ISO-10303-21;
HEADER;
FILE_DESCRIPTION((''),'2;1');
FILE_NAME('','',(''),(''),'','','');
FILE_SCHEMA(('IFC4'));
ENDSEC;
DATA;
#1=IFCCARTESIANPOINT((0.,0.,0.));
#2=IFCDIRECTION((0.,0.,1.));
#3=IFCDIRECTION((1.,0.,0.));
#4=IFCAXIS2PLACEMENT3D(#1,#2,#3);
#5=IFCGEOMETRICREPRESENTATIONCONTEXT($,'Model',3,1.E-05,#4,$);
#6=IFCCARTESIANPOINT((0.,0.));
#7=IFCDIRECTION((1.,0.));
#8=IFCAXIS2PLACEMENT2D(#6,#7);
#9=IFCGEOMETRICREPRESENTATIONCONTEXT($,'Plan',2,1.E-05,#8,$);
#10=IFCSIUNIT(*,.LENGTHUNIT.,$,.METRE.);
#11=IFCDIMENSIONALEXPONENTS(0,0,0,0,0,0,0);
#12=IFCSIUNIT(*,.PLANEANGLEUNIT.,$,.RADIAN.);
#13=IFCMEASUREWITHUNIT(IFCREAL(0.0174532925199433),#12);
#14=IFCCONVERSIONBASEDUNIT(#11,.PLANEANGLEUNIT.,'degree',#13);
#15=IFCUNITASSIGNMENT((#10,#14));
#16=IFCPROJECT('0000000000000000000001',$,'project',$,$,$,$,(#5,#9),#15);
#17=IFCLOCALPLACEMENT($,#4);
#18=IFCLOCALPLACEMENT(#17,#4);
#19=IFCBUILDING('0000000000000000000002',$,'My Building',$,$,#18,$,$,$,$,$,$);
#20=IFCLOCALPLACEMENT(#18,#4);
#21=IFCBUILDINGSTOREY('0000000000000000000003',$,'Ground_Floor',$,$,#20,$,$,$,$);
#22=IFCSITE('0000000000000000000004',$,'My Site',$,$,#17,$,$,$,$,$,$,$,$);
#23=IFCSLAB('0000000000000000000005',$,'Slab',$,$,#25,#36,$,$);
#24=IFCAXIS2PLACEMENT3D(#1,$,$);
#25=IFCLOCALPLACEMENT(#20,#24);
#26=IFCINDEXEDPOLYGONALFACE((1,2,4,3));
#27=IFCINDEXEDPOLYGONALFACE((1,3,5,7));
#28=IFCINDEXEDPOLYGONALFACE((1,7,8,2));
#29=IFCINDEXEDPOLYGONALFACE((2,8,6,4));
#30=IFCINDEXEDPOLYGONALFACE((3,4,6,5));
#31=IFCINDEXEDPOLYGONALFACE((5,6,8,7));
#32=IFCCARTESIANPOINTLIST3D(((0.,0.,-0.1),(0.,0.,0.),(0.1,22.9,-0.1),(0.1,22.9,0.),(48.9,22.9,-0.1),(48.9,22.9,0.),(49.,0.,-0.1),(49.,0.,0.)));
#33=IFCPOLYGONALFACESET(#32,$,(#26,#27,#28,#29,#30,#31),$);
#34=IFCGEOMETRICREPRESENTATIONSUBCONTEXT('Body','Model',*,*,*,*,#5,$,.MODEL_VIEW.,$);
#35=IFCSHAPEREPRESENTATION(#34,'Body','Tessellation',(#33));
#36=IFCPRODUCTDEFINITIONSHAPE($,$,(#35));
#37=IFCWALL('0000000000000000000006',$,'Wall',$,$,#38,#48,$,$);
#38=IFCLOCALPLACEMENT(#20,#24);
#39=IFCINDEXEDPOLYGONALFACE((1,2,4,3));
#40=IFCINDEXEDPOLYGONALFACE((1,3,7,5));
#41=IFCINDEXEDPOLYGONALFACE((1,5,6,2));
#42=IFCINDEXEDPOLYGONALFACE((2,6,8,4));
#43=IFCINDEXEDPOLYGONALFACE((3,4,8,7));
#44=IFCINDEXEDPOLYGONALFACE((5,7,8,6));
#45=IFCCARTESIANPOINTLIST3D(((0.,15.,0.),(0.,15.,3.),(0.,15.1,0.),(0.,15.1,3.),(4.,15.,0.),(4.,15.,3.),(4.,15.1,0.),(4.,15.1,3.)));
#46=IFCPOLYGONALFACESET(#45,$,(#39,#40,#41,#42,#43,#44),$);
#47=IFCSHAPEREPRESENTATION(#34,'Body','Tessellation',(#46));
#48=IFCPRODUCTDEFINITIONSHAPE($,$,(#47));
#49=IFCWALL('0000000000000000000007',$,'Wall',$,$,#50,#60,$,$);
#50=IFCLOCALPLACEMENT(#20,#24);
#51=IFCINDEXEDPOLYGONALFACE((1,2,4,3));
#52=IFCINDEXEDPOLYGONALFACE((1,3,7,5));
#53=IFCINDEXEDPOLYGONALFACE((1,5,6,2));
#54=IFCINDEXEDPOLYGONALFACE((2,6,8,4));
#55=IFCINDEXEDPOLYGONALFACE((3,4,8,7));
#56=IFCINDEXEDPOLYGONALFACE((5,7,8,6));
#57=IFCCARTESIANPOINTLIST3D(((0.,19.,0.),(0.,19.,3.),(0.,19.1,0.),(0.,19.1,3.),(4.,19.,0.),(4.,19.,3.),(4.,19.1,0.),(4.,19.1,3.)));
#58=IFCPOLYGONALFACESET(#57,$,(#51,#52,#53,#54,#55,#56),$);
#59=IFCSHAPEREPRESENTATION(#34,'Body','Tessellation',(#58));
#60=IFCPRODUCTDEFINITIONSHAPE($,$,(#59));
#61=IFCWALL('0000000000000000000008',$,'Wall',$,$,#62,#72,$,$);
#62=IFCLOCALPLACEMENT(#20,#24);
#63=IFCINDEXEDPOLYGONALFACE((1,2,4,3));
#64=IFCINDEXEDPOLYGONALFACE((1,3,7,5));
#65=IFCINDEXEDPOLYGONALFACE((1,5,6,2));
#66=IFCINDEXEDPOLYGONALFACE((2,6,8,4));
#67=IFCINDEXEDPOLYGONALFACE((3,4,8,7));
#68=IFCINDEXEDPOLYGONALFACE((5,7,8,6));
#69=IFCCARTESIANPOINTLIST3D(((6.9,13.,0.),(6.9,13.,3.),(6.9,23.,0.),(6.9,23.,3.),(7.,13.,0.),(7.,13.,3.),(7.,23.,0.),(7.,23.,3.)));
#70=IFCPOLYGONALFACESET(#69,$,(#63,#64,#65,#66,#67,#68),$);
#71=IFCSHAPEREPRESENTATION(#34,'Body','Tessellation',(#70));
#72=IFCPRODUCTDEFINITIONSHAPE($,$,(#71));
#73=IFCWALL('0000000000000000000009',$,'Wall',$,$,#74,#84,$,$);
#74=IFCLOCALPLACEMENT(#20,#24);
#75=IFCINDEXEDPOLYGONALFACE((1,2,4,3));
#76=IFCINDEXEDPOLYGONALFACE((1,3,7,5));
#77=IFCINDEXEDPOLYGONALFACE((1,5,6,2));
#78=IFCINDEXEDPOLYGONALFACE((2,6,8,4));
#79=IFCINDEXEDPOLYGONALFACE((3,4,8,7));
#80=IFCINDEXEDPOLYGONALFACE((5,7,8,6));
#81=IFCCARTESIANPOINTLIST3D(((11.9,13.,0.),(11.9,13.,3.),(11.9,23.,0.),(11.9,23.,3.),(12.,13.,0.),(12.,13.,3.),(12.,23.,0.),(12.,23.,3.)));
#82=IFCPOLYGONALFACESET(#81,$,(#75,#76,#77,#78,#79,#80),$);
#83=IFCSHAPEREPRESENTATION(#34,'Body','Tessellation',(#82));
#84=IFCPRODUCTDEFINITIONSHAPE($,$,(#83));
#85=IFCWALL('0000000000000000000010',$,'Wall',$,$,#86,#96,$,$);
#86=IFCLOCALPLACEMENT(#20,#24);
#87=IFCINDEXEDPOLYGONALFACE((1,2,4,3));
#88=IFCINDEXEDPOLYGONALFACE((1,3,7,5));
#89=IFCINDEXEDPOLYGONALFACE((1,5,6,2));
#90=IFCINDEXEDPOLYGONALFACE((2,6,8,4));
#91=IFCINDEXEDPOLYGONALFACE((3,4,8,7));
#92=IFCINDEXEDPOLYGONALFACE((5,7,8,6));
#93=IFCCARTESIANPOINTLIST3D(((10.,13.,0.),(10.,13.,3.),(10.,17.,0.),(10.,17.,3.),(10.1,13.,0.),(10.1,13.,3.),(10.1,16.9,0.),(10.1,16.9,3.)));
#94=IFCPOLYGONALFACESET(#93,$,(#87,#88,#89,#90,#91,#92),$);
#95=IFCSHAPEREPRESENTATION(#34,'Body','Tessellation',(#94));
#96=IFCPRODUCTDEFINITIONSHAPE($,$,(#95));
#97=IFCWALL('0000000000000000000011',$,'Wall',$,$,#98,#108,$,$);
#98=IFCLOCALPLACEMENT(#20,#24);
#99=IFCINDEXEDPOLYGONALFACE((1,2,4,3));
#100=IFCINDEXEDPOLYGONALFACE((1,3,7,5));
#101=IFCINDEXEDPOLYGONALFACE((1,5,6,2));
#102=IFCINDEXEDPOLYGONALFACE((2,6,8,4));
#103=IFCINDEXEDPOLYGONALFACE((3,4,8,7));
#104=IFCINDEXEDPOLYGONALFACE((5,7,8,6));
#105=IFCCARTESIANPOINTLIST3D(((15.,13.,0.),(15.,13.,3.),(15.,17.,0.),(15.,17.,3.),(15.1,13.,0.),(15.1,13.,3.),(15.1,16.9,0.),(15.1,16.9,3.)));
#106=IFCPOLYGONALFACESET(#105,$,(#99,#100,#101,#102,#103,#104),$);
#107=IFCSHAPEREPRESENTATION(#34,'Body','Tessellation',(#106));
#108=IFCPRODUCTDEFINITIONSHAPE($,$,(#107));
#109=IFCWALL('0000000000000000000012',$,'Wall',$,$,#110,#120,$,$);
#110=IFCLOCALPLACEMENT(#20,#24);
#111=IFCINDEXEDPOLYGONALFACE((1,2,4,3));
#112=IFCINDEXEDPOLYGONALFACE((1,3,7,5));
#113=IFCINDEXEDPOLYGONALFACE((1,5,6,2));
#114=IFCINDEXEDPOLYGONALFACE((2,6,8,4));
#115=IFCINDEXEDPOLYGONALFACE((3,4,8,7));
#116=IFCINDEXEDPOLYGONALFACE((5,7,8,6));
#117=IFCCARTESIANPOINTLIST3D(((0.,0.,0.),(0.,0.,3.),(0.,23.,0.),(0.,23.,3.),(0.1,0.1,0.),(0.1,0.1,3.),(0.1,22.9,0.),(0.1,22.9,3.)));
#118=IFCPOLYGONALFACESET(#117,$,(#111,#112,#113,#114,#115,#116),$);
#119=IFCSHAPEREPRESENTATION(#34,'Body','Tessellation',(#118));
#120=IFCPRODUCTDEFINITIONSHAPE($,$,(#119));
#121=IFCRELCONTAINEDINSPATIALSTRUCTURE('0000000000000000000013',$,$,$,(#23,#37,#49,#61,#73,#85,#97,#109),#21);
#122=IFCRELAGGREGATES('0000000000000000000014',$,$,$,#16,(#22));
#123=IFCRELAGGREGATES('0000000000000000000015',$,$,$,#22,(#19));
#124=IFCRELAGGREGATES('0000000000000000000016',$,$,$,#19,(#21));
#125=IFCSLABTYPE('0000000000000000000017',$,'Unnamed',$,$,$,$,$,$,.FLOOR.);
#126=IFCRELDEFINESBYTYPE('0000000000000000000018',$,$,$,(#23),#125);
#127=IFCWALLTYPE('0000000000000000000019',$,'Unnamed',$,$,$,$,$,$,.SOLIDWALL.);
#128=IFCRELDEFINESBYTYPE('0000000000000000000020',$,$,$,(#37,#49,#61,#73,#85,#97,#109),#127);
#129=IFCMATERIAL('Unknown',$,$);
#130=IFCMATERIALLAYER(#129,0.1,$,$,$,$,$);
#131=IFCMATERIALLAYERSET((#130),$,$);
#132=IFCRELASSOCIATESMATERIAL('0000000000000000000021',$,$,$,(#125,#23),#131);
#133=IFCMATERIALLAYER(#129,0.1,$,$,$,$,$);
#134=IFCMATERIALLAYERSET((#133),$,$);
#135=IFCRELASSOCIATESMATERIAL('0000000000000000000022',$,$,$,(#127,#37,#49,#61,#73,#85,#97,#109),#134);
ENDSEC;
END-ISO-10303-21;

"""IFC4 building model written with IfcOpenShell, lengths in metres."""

from ifc_helpers import new_model, entity, si_unit, converted_unit, frame, origin_with_axes, origin_2d_with_axis, place, context, subcontext, project, spatial, line, indexed_curve, outline, extrude, material, layer, layer_set, layer_usage, type_object, element, save


model = new_model("IFC4")

# Units and contexts
model_context = context("Model", 3, precision=1e-05, world=origin_with_axes())
plan_context = context("Plan", 2, precision=1e-05, world=origin_2d_with_axis())
body_context_1 = subcontext(model_context, "Body", "Model", "MODEL_VIEW")
ifc_project = project(units=[si_unit("LENGTHUNIT", "METRE"), converted_unit("PLANEANGLEUNIT", "degree", entity("IfcReal", 0.0174532925199433), si_unit("PLANEANGLEUNIT", "RADIAN"), dimensions=[0, 0, 0, 0, 0, 0, 0])], contexts=[model_context, plan_context])

# Site, building, storey
site_placement = place(None, origin_with_axes())
site = spatial("IfcSite", under=ifc_project, at=site_placement, Name="My Site")
building_placement = place(site_placement, origin_with_axes())
building = spatial("IfcBuilding", under=site, at=building_placement, Name="My Building")
storey_placement = place(building_placement, origin_with_axes())
storey = spatial("IfcBuildingStorey", under=building, at=storey_placement, Name="Ground_Floor")

# Slab
ifc_material = material(Name="Unknown")
ifc_layer_1 = layer(ifc_material, 0.1)
ifc_layer_set_1 = layer_set([ifc_layer_1])
ifc_layer_usage_1 = layer_usage(ifc_layer_set_1, "AXIS3", "POSITIVE", -0.1)
slab_type = type_object("IfcSlabType", Name="Unnamed", PredefinedType="FLOOR", material=ifc_layer_set_1)
slab_placement = place(storey_placement, frame((0.1, 22.9, 0.0), z_axis=(0.0, 0.0, 1.0), x_axis=(1.0, 0.0, 0.0)))
element("IfcSlab", 1, at=slab_placement, inside=storey, type_object=slab_type, material=ifc_layer_usage_1, Name="Slab", context=body_context_1, shape_type="SweptSolid", body=[
    extrude(outline(indexed_curve([(0.0, 0.0), (48.8, 0.0), (48.9, -22.9), (-0.1, -22.9), (0.0, 0.0)])), frame((0.0, 0.0, -0.1), z_axis=(0.0, 0.0, 1.0), x_axis=(1.0, 0.0, 0.0)), (0.0, 0.0, 1.0), 0.1),
])

# Shared definitions
ifc_layer_2 = layer(ifc_material, 0.1)
ifc_layer_set_2 = layer_set([ifc_layer_2])
wall_type = type_object("IfcWallType", Name="Unnamed", PredefinedType="SOLIDWALL", material=ifc_layer_set_2)

# Walls
ifc_layer_usage_2 = layer_usage(ifc_layer_set_2, "AXIS2", "POSITIVE", 0.0)
wall_1_placement = place(storey_placement, frame((0.0, 15.0, 0.0), z_axis=(0.0, 0.0, 1.0), x_axis=(1.0, 0.0, 0.0)))
element("IfcWall", 2, at=wall_1_placement, inside=storey, type_object=wall_type, material=ifc_layer_usage_2, Name="Wall", context=body_context_1, shape_type="SweptSolid", body=[
    extrude(outline(indexed_curve([(0.0, 0.0), (0.0, 0.1), (4.0, 0.1), (4.0, 0.0)], segments=[line(1, 2, 3, 4, 1)])), origin_with_axes(), (0.0, 0.0, 1.0), 3.0),
])
ifc_layer_usage_3 = layer_usage(ifc_layer_set_2, "AXIS2", "POSITIVE", 0.0)
wall_2_placement = place(storey_placement, frame((0.0, 19.0, 0.0), z_axis=(0.0, 0.0, 1.0), x_axis=(1.0, 0.0, 0.0)))
element("IfcWall", 3, at=wall_2_placement, inside=storey, type_object=wall_type, material=ifc_layer_usage_3, Name="Wall", context=body_context_1, shape_type="SweptSolid", body=[
    extrude(outline(indexed_curve([(0.0, 0.0), (0.0, 0.1), (4.0, 0.1), (4.0, 0.0)], segments=[line(1, 2, 3, 4, 1)])), origin_with_axes(), (0.0, 0.0, 1.0), 3.0),
])
ifc_layer_usage_4 = layer_usage(ifc_layer_set_2, "AXIS2", "POSITIVE", 0.0)
wall_3_placement = place(storey_placement, frame((7.0, 13.0, 0.0), z_axis=(0.0, 0.0, 1.0), x_axis=(0.0, 1.0, 0.0)))
element("IfcWall", 4, at=wall_3_placement, inside=storey, type_object=wall_type, material=ifc_layer_usage_4, Name="Wall", context=body_context_1, shape_type="SweptSolid", body=[
    extrude(outline(indexed_curve([(0.0, 0.0), (0.0, 0.1), (10.0, 0.1), (10.0, 0.0)], segments=[line(1, 2, 3, 4, 1)])), origin_with_axes(), (0.0, 0.0, 1.0), 3.0),
])
ifc_layer_usage_5 = layer_usage(ifc_layer_set_2, "AXIS2", "POSITIVE", 0.0)
wall_4_placement = place(storey_placement, frame((12.0, 13.0, 0.0), z_axis=(0.0, 0.0, 1.0), x_axis=(0.0, 1.0, 0.0)))
element("IfcWall", 5, at=wall_4_placement, inside=storey, type_object=wall_type, material=ifc_layer_usage_5, Name="Wall", context=body_context_1, shape_type="SweptSolid", body=[
    extrude(outline(indexed_curve([(0.0, 0.0), (0.0, 0.1), (10.0, 0.1), (10.0, 0.0)], segments=[line(1, 2, 3, 4, 1)])), origin_with_axes(), (0.0, 0.0, 1.0), 3.0),
])
ifc_layer_usage_6 = layer_usage(ifc_layer_set_2, "AXIS2", "POSITIVE", 0.0)
wall_5_placement = place(storey_placement, frame((10.0, 17.0, 0.0), z_axis=(0.0, 0.0, 1.0), x_axis=(0.0, -1.0, 0.0)))
element("IfcWall", 6, at=wall_5_placement, inside=storey, type_object=wall_type, material=ifc_layer_usage_6, Name="Wall", context=body_context_1, shape_type="SweptSolid", body=[
    extrude(outline(indexed_curve([(0.0, 0.0), (0.1, 0.1), (4.0, 0.1), (4.0, 0.0)], segments=[line(1, 2, 3, 4, 1)])), origin_with_axes(), (0.0, 0.0, 1.0), 3.0),
])
ifc_layer_usage_7 = layer_usage(ifc_layer_set_2, "AXIS2", "POSITIVE", 0.0)
wall_6_placement = place(storey_placement, frame((15.0, 17.0, 0.0), z_axis=(0.0, 0.0, 1.0), x_axis=(0.0, -1.0, 0.0)))
element("IfcWall", 7, at=wall_6_placement, inside=storey, type_object=wall_type, material=ifc_layer_usage_7, Name="Wall", context=body_context_1, shape_type="SweptSolid", body=[
    extrude(outline(indexed_curve([(0.0, 0.0), (0.1, 0.1), (4.0, 0.1), (4.0, 0.0)], segments=[line(1, 2, 3, 4, 1)])), origin_with_axes(), (0.0, 0.0, 1.0), 3.0),
])
ifc_layer_usage_8 = layer_usage(ifc_layer_set_2, "AXIS2", "POSITIVE", 0.0)
wall_7_placement = place(storey_placement, frame((0.0, 23.0, 0.0), z_axis=(0.0, 0.0, 1.0), x_axis=(0.0, -1.0, 0.0)))
element("IfcWall", 8, at=wall_7_placement, inside=storey, type_object=wall_type, material=ifc_layer_usage_8, Name="Wall", context=body_context_1, shape_type="SweptSolid", body=[
    extrude(outline(indexed_curve([(0.0, 0.0), (0.1, 0.1), (22.9, 0.1), (23.0, 0.0)], segments=[line(1, 2, 3, 4, 1)])), origin_with_axes(), (0.0, 0.0, 1.0), 3.0),
])

save(model, "model.ifc")
